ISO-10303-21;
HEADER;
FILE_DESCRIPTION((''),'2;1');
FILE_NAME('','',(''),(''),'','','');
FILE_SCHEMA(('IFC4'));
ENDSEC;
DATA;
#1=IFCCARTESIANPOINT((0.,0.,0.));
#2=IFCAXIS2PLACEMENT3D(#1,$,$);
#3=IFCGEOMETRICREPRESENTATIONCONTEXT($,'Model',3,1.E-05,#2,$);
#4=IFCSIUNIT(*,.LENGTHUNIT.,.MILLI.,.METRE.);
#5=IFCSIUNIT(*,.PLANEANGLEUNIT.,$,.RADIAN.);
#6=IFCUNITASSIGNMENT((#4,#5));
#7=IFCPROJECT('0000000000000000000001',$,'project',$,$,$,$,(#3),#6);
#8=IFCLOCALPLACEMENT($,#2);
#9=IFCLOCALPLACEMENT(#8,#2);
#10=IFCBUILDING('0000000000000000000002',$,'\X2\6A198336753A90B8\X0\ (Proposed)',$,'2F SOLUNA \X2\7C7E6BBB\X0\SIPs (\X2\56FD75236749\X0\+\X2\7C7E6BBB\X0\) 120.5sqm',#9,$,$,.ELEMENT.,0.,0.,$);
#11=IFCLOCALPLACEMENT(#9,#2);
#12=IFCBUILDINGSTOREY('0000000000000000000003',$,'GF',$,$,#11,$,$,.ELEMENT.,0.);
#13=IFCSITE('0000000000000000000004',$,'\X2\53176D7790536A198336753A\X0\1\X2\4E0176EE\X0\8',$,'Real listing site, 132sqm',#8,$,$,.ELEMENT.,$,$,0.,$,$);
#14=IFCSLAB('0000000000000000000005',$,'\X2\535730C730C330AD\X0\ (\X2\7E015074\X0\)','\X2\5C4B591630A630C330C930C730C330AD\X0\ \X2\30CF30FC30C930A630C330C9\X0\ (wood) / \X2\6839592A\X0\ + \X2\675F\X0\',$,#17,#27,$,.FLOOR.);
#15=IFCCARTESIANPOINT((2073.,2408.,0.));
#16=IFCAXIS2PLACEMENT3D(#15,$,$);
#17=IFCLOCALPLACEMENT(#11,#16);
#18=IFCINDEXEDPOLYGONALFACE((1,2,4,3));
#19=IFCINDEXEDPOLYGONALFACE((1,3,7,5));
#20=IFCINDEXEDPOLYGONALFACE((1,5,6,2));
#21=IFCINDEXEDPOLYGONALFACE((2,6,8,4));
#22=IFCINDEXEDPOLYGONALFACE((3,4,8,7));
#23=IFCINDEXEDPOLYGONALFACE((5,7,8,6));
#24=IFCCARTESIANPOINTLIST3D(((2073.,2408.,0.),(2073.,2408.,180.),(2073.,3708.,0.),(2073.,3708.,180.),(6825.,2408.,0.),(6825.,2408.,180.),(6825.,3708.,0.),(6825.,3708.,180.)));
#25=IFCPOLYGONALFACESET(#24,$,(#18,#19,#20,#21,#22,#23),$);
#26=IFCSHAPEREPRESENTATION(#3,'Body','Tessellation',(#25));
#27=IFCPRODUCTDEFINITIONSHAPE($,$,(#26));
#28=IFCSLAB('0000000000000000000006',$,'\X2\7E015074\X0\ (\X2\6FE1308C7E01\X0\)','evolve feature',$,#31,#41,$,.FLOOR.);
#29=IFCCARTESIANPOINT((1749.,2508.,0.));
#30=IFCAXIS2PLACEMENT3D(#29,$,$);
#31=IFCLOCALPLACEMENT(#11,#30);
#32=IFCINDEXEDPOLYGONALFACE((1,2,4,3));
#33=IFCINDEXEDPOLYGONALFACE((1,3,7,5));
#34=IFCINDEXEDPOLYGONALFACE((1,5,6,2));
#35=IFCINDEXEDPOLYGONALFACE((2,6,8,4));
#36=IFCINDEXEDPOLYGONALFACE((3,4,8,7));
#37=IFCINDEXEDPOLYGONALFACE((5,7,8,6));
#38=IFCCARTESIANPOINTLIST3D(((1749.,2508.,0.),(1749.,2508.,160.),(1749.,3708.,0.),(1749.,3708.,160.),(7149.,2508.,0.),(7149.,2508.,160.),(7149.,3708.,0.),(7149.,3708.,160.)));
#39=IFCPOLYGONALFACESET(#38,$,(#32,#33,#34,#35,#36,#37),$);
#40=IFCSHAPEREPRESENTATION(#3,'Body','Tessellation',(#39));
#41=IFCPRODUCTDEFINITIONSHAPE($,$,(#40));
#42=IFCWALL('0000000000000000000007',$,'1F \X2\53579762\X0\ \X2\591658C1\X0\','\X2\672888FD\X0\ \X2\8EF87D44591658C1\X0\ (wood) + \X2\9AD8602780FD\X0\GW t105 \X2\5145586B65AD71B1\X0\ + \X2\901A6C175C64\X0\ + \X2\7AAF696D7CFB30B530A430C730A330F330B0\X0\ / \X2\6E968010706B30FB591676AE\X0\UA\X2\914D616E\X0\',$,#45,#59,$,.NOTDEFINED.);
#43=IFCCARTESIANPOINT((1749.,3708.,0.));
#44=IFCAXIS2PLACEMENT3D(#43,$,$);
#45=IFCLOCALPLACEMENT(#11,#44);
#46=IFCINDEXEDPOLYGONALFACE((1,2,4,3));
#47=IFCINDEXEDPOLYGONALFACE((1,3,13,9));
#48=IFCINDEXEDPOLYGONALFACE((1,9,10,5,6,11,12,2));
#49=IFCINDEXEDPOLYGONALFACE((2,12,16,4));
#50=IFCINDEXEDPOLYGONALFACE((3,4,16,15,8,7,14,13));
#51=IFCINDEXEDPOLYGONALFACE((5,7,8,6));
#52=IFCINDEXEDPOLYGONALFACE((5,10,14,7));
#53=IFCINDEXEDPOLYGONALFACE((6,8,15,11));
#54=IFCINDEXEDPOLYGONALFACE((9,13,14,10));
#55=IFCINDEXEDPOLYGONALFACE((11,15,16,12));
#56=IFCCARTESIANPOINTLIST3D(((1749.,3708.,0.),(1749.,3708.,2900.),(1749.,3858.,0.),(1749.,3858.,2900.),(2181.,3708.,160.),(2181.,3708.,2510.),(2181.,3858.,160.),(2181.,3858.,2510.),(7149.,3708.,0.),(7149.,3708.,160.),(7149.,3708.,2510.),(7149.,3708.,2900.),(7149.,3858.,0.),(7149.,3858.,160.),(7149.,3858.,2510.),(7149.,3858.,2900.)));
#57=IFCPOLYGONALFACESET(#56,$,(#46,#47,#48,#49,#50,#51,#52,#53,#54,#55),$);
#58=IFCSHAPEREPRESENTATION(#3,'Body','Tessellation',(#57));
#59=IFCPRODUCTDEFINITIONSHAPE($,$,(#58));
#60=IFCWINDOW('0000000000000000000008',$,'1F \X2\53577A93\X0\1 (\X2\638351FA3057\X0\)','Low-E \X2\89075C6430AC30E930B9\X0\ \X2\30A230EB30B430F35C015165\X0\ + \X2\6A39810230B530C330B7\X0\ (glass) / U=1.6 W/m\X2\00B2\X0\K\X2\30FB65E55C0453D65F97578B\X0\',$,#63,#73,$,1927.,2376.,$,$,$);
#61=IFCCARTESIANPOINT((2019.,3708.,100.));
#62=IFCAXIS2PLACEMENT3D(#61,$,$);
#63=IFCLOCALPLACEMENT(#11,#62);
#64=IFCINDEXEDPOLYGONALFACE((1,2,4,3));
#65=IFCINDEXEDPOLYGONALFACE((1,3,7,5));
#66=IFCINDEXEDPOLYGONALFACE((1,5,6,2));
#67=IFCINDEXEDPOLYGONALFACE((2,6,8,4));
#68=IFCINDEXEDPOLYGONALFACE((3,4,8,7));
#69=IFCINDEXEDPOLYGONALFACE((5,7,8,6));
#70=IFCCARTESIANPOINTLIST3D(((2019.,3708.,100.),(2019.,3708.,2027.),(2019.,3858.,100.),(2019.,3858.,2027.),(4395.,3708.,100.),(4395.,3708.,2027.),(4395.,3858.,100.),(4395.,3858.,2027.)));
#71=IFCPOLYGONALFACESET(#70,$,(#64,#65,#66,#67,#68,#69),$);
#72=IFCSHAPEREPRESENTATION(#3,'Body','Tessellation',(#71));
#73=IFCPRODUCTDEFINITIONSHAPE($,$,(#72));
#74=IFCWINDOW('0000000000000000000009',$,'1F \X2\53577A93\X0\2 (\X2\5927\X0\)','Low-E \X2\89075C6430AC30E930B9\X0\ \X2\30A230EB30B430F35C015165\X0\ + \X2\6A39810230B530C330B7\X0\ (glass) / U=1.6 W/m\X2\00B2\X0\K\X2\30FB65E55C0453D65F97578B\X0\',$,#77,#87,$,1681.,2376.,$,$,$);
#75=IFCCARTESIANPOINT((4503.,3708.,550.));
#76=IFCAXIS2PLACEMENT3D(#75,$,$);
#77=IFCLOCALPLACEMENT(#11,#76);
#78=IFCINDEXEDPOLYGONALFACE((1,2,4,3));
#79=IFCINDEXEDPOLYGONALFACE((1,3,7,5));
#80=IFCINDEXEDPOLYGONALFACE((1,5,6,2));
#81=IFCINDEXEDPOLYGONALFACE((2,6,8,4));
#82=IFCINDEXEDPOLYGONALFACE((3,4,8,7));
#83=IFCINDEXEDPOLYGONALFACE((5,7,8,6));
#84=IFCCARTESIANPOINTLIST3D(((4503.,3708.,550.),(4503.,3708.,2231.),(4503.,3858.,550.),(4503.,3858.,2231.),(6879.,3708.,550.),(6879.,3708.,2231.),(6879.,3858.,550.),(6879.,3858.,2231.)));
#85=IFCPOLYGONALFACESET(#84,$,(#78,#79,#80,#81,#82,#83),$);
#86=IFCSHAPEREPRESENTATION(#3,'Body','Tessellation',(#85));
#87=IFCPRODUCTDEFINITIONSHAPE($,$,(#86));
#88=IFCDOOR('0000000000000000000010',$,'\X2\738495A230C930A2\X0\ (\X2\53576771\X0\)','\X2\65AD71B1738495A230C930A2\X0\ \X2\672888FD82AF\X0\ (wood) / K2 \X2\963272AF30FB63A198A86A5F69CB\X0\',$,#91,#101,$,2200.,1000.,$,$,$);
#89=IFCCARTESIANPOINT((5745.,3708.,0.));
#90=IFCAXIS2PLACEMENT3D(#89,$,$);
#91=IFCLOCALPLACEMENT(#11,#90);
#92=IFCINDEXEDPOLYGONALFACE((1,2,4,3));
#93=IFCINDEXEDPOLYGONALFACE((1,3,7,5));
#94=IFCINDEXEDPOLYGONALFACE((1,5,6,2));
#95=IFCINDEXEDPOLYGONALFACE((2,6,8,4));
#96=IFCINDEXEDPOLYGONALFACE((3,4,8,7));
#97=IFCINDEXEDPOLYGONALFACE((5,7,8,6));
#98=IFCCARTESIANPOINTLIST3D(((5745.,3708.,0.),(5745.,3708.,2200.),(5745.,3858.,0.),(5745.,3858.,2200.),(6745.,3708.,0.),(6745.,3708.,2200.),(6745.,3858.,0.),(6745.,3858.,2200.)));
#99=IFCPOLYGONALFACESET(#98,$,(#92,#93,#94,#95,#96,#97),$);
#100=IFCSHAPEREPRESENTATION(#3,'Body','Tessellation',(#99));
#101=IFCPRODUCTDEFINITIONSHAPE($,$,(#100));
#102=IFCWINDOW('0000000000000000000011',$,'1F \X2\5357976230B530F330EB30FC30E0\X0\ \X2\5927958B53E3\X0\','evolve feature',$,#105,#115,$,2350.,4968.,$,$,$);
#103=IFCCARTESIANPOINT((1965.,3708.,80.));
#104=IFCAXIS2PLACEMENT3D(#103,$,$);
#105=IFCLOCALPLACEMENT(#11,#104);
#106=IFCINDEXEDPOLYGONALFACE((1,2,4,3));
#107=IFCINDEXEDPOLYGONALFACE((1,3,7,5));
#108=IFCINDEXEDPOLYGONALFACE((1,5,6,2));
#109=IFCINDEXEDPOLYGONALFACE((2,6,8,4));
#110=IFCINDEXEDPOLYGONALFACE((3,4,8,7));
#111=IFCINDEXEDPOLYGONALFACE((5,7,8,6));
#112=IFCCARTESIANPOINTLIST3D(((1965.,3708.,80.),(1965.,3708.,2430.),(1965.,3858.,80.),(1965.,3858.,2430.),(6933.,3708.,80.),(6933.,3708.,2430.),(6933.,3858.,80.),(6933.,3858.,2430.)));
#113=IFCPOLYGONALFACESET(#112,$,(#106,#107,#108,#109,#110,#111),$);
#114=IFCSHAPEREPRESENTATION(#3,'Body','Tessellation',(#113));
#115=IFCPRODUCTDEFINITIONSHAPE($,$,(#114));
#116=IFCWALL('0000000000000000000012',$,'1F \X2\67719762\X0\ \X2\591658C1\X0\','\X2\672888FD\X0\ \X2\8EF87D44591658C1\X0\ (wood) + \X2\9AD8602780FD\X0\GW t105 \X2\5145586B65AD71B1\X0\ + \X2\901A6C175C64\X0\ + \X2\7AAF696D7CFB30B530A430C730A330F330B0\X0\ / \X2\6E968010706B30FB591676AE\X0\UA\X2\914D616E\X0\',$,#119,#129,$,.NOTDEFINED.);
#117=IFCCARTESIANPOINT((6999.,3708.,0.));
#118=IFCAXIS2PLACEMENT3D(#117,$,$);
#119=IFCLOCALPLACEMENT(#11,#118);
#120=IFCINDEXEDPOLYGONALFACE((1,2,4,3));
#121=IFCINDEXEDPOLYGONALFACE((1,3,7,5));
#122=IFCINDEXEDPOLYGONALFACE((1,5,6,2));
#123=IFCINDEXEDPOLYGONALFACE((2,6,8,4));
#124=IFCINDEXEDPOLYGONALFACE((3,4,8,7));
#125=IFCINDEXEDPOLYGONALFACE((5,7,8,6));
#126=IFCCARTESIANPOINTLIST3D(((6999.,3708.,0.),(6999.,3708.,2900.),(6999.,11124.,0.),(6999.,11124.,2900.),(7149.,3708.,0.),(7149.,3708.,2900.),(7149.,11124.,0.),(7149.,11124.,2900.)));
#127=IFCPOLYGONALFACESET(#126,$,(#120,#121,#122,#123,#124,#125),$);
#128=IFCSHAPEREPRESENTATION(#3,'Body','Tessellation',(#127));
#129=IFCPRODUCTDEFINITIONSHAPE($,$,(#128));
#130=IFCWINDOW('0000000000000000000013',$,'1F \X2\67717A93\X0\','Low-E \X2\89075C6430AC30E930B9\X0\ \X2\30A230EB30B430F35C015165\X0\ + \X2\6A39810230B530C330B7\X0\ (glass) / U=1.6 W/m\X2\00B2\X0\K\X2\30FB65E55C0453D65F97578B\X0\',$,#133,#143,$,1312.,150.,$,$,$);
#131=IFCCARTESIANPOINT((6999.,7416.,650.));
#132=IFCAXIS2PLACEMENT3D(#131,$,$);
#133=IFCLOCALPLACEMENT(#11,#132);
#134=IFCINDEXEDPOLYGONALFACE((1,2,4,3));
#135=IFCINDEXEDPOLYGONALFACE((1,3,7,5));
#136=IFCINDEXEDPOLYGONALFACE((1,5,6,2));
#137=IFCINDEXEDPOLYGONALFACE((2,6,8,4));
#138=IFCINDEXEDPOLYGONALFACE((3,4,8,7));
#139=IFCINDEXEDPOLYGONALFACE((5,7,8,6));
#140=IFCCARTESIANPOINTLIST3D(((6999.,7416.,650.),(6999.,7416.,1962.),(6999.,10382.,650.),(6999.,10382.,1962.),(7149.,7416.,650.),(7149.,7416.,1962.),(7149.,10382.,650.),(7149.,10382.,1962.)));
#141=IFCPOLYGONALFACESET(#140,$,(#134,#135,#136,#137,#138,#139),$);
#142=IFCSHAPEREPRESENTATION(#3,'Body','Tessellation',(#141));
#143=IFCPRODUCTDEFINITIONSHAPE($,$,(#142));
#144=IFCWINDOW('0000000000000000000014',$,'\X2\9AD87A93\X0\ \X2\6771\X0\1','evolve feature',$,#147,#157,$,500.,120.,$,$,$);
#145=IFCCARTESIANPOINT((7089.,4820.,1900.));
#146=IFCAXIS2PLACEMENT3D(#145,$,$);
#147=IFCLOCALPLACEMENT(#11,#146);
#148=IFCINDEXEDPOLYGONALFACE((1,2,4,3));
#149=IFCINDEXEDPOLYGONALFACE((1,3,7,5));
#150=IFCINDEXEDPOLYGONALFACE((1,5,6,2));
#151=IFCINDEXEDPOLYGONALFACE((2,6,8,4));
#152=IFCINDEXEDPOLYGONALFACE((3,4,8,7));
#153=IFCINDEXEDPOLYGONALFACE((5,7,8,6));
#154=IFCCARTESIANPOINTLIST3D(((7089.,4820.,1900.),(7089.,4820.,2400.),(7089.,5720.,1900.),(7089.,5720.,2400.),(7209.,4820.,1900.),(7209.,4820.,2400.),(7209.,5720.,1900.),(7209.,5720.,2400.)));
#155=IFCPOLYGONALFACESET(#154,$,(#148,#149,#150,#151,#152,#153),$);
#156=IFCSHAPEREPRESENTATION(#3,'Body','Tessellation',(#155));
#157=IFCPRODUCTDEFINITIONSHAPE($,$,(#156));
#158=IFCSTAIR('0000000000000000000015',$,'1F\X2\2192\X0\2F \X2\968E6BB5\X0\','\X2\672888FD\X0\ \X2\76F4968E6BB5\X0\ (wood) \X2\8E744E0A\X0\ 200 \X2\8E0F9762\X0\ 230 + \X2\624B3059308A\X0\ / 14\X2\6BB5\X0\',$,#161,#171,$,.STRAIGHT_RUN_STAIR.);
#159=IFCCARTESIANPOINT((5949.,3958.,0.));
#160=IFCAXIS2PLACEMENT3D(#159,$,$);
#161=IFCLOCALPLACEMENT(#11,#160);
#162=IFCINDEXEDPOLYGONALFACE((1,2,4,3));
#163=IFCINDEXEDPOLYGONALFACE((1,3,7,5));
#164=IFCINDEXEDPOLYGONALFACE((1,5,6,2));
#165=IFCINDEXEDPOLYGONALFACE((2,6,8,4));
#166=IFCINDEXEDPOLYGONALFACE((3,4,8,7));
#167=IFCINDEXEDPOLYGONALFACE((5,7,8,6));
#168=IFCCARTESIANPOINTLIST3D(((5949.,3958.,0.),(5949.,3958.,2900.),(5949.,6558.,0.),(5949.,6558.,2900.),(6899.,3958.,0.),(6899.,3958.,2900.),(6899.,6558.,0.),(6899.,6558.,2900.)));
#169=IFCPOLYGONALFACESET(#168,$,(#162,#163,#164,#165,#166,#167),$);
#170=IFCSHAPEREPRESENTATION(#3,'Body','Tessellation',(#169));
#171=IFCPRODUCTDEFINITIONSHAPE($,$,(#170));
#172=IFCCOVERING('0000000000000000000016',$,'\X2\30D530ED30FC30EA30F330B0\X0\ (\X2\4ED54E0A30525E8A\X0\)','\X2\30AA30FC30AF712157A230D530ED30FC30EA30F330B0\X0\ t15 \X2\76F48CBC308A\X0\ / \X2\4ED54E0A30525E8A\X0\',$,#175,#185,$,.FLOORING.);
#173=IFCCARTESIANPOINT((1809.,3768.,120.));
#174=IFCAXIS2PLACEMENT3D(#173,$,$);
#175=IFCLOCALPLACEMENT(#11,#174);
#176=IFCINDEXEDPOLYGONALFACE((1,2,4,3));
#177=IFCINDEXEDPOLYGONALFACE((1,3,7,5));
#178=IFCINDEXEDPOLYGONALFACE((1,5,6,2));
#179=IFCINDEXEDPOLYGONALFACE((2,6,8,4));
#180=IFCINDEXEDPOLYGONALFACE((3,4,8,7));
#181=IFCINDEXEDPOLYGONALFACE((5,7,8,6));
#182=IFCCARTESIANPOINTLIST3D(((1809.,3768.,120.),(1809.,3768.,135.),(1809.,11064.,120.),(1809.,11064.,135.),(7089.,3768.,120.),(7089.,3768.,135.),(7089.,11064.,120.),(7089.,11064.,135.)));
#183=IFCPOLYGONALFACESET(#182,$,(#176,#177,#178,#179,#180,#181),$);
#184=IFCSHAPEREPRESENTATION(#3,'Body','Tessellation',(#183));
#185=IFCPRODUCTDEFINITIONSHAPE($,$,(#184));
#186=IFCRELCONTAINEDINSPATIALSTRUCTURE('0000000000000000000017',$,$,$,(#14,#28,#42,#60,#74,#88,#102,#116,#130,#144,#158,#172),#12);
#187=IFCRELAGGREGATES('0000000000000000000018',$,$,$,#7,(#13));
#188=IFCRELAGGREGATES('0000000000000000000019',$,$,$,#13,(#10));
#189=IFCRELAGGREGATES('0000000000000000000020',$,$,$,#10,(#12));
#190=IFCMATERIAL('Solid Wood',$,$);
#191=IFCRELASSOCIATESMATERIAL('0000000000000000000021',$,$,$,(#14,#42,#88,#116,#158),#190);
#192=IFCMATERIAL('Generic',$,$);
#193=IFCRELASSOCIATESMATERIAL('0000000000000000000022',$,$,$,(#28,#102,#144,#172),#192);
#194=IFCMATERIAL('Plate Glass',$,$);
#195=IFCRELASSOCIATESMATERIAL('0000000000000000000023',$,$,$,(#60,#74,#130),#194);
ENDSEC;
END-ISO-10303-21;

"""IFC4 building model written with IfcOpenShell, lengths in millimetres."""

from ifc_helpers import new_model, si_unit, frame, frame_2d, origin, place, context, project, spatial, rectangle, extrude, material, element, fill, save


model = new_model("IFC4")

# Units and contexts
model_context = context("Model", 3, precision=1e-05, world=origin())
ifc_project = project(units=[si_unit("LENGTHUNIT", "METRE", prefix="MILLI"), si_unit("PLANEANGLEUNIT", "RADIAN")], contexts=[model_context])

# Site, building, storey
site_placement = place(None, origin())
site = spatial("IfcSite", under=ifc_project, at=site_placement, Name="北海道標茶町1丁目8", ObjectType="Real listing site, 132sqm", CompositionType="ELEMENT", RefElevation=0.0)
building_placement = place(site_placement, origin())
building = spatial("IfcBuilding", under=site, at=building_placement, Name="標茶町邸 (Proposed)", ObjectType="2F SOLUNA 籾殻SIPs (国産杉+籾殻) 120.5sqm", CompositionType="ELEMENT", ElevationOfRefHeight=0.0, ElevationOfTerrain=0.0)
storey_placement = place(building_placement, origin())
storey = spatial("IfcBuildingStorey", under=building, at=storey_placement, Name="GF", CompositionType="ELEMENT", Elevation=0.0)

# Slabs
ifc_material_1 = material(Name="Solid Wood")
slab_1_placement = place(storey_placement, frame((2073.0, 2408.0, 0.0)))
element("IfcSlab", 1, at=slab_1_placement, inside=storey, material=ifc_material_1, Name="南デッキ (縁側)", Description="屋外ウッドデッキ ハードウッド (wood) / 根太 + 束", PredefinedType="FLOOR", context=model_context, shape_type="SweptSolid", body=[
    extrude(rectangle(XDim=4752.0, YDim=1300.0, at=frame_2d((2376.0, 650.0))), frame((2073.0, 2408.0, 0.0)), (0.0, 0.0, 1.0), 180.0),
])
ifc_material_2 = material(Name="Generic")
slab_2_placement = place(storey_placement, frame((1749.0, 2508.0, 0.0)))
element("IfcSlab", 2, at=slab_2_placement, inside=storey, material=ifc_material_2, Name="縁側 (濡れ縁)", Description="evolve feature", PredefinedType="FLOOR", context=model_context, shape_type="SweptSolid", body=[
    extrude(rectangle(XDim=5400.0, YDim=1200.0, at=frame_2d((2700.0, 600.0))), frame((1749.0, 2508.0, 0.0)), (0.0, 0.0, 1.0), 160.0),
])

# Wall, openings, windows, door
wall_1_placement = place(storey_placement, frame((1749.0, 3708.0, 0.0)))
wall_1 = element("IfcWall", 3, at=wall_1_placement, inside=storey, material=ifc_material_1, Name="1F 南面 外壁", Description="木製 軸組外壁 (wood) + 高性能GW t105 充填断熱 + 通気層 + 窯業系サイディング / 準耐火・外皮UA配慮", PredefinedType="NOTDEFINED", context=model_context, shape_type="SweptSolid", body=[
    extrude(rectangle(XDim=5400.0, YDim=150.0, at=frame_2d((2700.0, 75.0))), frame((1749.0, 3708.0, 0.0)), (0.0, 0.0, 1.0), 2900.0),
])
opening_1_placement = place(storey_placement, frame((2019.0, 3708.0, 100.0)))
opening_1 = element("IfcOpeningElement", 4, at=opening_1_placement, cuts=wall_1, PredefinedType="NOTDEFINED", context=model_context, shape_type="SweptSolid", body=[
    extrude(rectangle(XDim=2376.0, YDim=150.0, at=frame_2d((1188.0, 75.0))), frame((2019.0, 3708.0, 100.0)), (0.0, 0.0, 1.0), 1927.0),
])
opening_2_placement = place(storey_placement, frame((4503.0, 3708.0, 550.0)))
opening_2 = element("IfcOpeningElement", 5, at=opening_2_placement, cuts=wall_1, PredefinedType="NOTDEFINED", context=model_context, shape_type="SweptSolid", body=[
    extrude(rectangle(XDim=2376.0, YDim=150.0, at=frame_2d((1188.0, 75.0))), frame((4503.0, 3708.0, 550.0)), (0.0, 0.0, 1.0), 1681.0),
])
opening_3_placement = place(storey_placement, frame((5745.0, 3708.0, 0.0)))
opening_3 = element("IfcOpeningElement", 6, at=opening_3_placement, cuts=wall_1, PredefinedType="NOTDEFINED", context=model_context, shape_type="SweptSolid", body=[
    extrude(rectangle(XDim=1000.0, YDim=150.0, at=frame_2d((500.0, 75.0))), frame((5745.0, 3708.0, 0.0)), (0.0, 0.0, 1.0), 2200.0),
])
opening_4_placement = place(storey_placement, frame((1965.0, 3708.0, 80.0)))
opening_4 = element("IfcOpeningElement", 7, at=opening_4_placement, cuts=wall_1, PredefinedType="NOTDEFINED", context=model_context, shape_type="SweptSolid", body=[
    extrude(rectangle(XDim=4968.0, YDim=150.0, at=frame_2d((2484.0, 75.0))), frame((1965.0, 3708.0, 80.0)), (0.0, 0.0, 1.0), 2350.0),
])
ifc_material_3 = material(Name="Plate Glass")
window_1_placement = place(storey_placement, frame((2019.0, 3708.0, 100.0)))
window_1 = element("IfcWindow", 8, at=window_1_placement, inside=storey, material=ifc_material_3, Name="1F 南窓1 (掃出し)", Description="Low-E 複層ガラス アルゴン封入 + 樹脂サッシ (glass) / U=1.6 W/m²K・日射取得型", OverallHeight=1927.0, OverallWidth=2376.0, context=model_context, shape_type="SweptSolid", body=[
    extrude(rectangle(XDim=2376.0, YDim=150.0, at=frame_2d((1188.0, 75.0))), frame((2019.0, 3708.0, 100.0)), (0.0, 0.0, 1.0), 1927.0),
])
fill(opening_1, window_1)
window_2_placement = place(storey_placement, frame((4503.0, 3708.0, 550.0)))
window_2 = element("IfcWindow", 9, at=window_2_placement, inside=storey, material=ifc_material_3, Name="1F 南窓2 (大)", Description="Low-E 複層ガラス アルゴン封入 + 樹脂サッシ (glass) / U=1.6 W/m²K・日射取得型", OverallHeight=1681.0, OverallWidth=2376.0, context=model_context, shape_type="SweptSolid", body=[
    extrude(rectangle(XDim=2376.0, YDim=150.0, at=frame_2d((1188.0, 75.0))), frame((4503.0, 3708.0, 550.0)), (0.0, 0.0, 1.0), 1681.0),
])
fill(opening_2, window_2)
door_placement = place(storey_placement, frame((5745.0, 3708.0, 0.0)))
door = element("IfcDoor", 10, at=door_placement, inside=storey, material=ifc_material_1, Name="玄関ドア (南東)", Description="断熱玄関ドア 木製芯 (wood) / K2 防犯・採風機構", OverallHeight=2200.0, OverallWidth=1000.0, context=model_context, shape_type="SweptSolid", body=[
    extrude(rectangle(XDim=1000.0, YDim=150.0, at=frame_2d((500.0, 75.0))), frame((5745.0, 3708.0, 0.0)), (0.0, 0.0, 1.0), 2200.0),
])
fill(opening_3, door)
window_3_placement = place(storey_placement, frame((1965.0, 3708.0, 80.0)))
window_3 = element("IfcWindow", 11, at=window_3_placement, inside=storey, material=ifc_material_2, Name="1F 南面サンルーム 大開口", Description="evolve feature", OverallHeight=2350.0, OverallWidth=4968.0, context=model_context, shape_type="SweptSolid", body=[
    extrude(rectangle(XDim=4968.0, YDim=150.0, at=frame_2d((2484.0, 75.0))), frame((1965.0, 3708.0, 80.0)), (0.0, 0.0, 1.0), 2350.0),
])
fill(opening_4, window_3)

# Wall, openings, windows
wall_2_placement = place(storey_placement, frame((6999.0, 3708.0, 0.0)))
wall_2 = element("IfcWall", 12, at=wall_2_placement, inside=storey, material=ifc_material_1, Name="1F 東面 外壁", Description="木製 軸組外壁 (wood) + 高性能GW t105 充填断熱 + 通気層 + 窯業系サイディング / 準耐火・外皮UA配慮", PredefinedType="NOTDEFINED", context=model_context, shape_type="SweptSolid", body=[
    extrude(rectangle(XDim=150.0, YDim=7416.0, at=frame_2d((75.0, 3708.0))), frame((6999.0, 3708.0, 0.0)), (0.0, 0.0, 1.0), 2900.0),
])
opening_5_placement = place(storey_placement, frame((6999.0, 7416.0, 650.0)))
opening_5 = element("IfcOpeningElement", 13, at=opening_5_placement, cuts=wall_2, PredefinedType="NOTDEFINED", context=model_context, shape_type="SweptSolid", body=[
    extrude(rectangle(XDim=150.0, YDim=2966.0, at=frame_2d((75.0, 1483.0))), frame((6999.0, 7416.0, 650.0)), (0.0, 0.0, 1.0), 1312.0),
])
opening_6_placement = place(storey_placement, frame((7089.0, 4820.0, 1900.0)))
opening_6 = element("IfcOpeningElement", 14, at=opening_6_placement, cuts=wall_2, PredefinedType="NOTDEFINED", context=model_context, shape_type="SweptSolid", body=[
    extrude(rectangle(XDim=120.0, YDim=900.0, at=frame_2d((60.0, 450.0))), frame((7089.0, 4820.0, 1900.0)), (0.0, 0.0, 1.0), 500.0),
])
window_4_placement = place(storey_placement, frame((6999.0, 7416.0, 650.0)))
window_4 = element("IfcWindow", 15, at=window_4_placement, inside=storey, material=ifc_material_3, Name="1F 東窓", Description="Low-E 複層ガラス アルゴン封入 + 樹脂サッシ (glass) / U=1.6 W/m²K・日射取得型", OverallHeight=1312.0, OverallWidth=150.0, context=model_context, shape_type="SweptSolid", body=[
    extrude(rectangle(XDim=150.0, YDim=2966.0, at=frame_2d((75.0, 1483.0))), frame((6999.0, 7416.0, 650.0)), (0.0, 0.0, 1.0), 1312.0),
])
fill(opening_5, window_4)
window_5_placement = place(storey_placement, frame((7089.0, 4820.0, 1900.0)))
window_5 = element("IfcWindow", 16, at=window_5_placement, inside=storey, material=ifc_material_2, Name="高窓 東1", Description="evolve feature", OverallHeight=500.0, OverallWidth=120.0, context=model_context, shape_type="SweptSolid", body=[
    extrude(rectangle(XDim=120.0, YDim=900.0, at=frame_2d((60.0, 450.0))), frame((7089.0, 4820.0, 1900.0)), (0.0, 0.0, 1.0), 500.0),
])
fill(opening_6, window_5)

# Stair
stair_placement = place(storey_placement, frame((5949.0, 3958.0, 0.0)))
element("IfcStair", 17, at=stair_placement, inside=storey, material=ifc_material_1, Name="1F→2F 階段", Description="木製 直階段 (wood) 蹴上 200 踏面 230 + 手すり / 14段", PredefinedType="STRAIGHT_RUN_STAIR", context=model_context, shape_type="SweptSolid", body=[
    extrude(rectangle(XDim=950.0, YDim=2600.0, at=frame_2d((475.0, 1300.0))), frame((5949.0, 3958.0, 0.0)), (0.0, 0.0, 1.0), 2900.0),
])

# Covering
covering_placement = place(storey_placement, frame((1809.0, 3768.0, 120.0)))
element("IfcCovering", 18, at=covering_placement, inside=storey, material=ifc_material_2, Name="フローリング (仕上げ床)", Description="オーク無垢フローリング t15 直貼り / 仕上げ床", PredefinedType="FLOORING", context=model_context, shape_type="SweptSolid", body=[
    extrude(rectangle(XDim=5280.0, YDim=7296.0, at=frame_2d((2640.0, 3648.0))), frame((1809.0, 3768.0, 120.0)), (0.0, 0.0, 1.0), 15.0),
])

save(model, "model.ifc")
